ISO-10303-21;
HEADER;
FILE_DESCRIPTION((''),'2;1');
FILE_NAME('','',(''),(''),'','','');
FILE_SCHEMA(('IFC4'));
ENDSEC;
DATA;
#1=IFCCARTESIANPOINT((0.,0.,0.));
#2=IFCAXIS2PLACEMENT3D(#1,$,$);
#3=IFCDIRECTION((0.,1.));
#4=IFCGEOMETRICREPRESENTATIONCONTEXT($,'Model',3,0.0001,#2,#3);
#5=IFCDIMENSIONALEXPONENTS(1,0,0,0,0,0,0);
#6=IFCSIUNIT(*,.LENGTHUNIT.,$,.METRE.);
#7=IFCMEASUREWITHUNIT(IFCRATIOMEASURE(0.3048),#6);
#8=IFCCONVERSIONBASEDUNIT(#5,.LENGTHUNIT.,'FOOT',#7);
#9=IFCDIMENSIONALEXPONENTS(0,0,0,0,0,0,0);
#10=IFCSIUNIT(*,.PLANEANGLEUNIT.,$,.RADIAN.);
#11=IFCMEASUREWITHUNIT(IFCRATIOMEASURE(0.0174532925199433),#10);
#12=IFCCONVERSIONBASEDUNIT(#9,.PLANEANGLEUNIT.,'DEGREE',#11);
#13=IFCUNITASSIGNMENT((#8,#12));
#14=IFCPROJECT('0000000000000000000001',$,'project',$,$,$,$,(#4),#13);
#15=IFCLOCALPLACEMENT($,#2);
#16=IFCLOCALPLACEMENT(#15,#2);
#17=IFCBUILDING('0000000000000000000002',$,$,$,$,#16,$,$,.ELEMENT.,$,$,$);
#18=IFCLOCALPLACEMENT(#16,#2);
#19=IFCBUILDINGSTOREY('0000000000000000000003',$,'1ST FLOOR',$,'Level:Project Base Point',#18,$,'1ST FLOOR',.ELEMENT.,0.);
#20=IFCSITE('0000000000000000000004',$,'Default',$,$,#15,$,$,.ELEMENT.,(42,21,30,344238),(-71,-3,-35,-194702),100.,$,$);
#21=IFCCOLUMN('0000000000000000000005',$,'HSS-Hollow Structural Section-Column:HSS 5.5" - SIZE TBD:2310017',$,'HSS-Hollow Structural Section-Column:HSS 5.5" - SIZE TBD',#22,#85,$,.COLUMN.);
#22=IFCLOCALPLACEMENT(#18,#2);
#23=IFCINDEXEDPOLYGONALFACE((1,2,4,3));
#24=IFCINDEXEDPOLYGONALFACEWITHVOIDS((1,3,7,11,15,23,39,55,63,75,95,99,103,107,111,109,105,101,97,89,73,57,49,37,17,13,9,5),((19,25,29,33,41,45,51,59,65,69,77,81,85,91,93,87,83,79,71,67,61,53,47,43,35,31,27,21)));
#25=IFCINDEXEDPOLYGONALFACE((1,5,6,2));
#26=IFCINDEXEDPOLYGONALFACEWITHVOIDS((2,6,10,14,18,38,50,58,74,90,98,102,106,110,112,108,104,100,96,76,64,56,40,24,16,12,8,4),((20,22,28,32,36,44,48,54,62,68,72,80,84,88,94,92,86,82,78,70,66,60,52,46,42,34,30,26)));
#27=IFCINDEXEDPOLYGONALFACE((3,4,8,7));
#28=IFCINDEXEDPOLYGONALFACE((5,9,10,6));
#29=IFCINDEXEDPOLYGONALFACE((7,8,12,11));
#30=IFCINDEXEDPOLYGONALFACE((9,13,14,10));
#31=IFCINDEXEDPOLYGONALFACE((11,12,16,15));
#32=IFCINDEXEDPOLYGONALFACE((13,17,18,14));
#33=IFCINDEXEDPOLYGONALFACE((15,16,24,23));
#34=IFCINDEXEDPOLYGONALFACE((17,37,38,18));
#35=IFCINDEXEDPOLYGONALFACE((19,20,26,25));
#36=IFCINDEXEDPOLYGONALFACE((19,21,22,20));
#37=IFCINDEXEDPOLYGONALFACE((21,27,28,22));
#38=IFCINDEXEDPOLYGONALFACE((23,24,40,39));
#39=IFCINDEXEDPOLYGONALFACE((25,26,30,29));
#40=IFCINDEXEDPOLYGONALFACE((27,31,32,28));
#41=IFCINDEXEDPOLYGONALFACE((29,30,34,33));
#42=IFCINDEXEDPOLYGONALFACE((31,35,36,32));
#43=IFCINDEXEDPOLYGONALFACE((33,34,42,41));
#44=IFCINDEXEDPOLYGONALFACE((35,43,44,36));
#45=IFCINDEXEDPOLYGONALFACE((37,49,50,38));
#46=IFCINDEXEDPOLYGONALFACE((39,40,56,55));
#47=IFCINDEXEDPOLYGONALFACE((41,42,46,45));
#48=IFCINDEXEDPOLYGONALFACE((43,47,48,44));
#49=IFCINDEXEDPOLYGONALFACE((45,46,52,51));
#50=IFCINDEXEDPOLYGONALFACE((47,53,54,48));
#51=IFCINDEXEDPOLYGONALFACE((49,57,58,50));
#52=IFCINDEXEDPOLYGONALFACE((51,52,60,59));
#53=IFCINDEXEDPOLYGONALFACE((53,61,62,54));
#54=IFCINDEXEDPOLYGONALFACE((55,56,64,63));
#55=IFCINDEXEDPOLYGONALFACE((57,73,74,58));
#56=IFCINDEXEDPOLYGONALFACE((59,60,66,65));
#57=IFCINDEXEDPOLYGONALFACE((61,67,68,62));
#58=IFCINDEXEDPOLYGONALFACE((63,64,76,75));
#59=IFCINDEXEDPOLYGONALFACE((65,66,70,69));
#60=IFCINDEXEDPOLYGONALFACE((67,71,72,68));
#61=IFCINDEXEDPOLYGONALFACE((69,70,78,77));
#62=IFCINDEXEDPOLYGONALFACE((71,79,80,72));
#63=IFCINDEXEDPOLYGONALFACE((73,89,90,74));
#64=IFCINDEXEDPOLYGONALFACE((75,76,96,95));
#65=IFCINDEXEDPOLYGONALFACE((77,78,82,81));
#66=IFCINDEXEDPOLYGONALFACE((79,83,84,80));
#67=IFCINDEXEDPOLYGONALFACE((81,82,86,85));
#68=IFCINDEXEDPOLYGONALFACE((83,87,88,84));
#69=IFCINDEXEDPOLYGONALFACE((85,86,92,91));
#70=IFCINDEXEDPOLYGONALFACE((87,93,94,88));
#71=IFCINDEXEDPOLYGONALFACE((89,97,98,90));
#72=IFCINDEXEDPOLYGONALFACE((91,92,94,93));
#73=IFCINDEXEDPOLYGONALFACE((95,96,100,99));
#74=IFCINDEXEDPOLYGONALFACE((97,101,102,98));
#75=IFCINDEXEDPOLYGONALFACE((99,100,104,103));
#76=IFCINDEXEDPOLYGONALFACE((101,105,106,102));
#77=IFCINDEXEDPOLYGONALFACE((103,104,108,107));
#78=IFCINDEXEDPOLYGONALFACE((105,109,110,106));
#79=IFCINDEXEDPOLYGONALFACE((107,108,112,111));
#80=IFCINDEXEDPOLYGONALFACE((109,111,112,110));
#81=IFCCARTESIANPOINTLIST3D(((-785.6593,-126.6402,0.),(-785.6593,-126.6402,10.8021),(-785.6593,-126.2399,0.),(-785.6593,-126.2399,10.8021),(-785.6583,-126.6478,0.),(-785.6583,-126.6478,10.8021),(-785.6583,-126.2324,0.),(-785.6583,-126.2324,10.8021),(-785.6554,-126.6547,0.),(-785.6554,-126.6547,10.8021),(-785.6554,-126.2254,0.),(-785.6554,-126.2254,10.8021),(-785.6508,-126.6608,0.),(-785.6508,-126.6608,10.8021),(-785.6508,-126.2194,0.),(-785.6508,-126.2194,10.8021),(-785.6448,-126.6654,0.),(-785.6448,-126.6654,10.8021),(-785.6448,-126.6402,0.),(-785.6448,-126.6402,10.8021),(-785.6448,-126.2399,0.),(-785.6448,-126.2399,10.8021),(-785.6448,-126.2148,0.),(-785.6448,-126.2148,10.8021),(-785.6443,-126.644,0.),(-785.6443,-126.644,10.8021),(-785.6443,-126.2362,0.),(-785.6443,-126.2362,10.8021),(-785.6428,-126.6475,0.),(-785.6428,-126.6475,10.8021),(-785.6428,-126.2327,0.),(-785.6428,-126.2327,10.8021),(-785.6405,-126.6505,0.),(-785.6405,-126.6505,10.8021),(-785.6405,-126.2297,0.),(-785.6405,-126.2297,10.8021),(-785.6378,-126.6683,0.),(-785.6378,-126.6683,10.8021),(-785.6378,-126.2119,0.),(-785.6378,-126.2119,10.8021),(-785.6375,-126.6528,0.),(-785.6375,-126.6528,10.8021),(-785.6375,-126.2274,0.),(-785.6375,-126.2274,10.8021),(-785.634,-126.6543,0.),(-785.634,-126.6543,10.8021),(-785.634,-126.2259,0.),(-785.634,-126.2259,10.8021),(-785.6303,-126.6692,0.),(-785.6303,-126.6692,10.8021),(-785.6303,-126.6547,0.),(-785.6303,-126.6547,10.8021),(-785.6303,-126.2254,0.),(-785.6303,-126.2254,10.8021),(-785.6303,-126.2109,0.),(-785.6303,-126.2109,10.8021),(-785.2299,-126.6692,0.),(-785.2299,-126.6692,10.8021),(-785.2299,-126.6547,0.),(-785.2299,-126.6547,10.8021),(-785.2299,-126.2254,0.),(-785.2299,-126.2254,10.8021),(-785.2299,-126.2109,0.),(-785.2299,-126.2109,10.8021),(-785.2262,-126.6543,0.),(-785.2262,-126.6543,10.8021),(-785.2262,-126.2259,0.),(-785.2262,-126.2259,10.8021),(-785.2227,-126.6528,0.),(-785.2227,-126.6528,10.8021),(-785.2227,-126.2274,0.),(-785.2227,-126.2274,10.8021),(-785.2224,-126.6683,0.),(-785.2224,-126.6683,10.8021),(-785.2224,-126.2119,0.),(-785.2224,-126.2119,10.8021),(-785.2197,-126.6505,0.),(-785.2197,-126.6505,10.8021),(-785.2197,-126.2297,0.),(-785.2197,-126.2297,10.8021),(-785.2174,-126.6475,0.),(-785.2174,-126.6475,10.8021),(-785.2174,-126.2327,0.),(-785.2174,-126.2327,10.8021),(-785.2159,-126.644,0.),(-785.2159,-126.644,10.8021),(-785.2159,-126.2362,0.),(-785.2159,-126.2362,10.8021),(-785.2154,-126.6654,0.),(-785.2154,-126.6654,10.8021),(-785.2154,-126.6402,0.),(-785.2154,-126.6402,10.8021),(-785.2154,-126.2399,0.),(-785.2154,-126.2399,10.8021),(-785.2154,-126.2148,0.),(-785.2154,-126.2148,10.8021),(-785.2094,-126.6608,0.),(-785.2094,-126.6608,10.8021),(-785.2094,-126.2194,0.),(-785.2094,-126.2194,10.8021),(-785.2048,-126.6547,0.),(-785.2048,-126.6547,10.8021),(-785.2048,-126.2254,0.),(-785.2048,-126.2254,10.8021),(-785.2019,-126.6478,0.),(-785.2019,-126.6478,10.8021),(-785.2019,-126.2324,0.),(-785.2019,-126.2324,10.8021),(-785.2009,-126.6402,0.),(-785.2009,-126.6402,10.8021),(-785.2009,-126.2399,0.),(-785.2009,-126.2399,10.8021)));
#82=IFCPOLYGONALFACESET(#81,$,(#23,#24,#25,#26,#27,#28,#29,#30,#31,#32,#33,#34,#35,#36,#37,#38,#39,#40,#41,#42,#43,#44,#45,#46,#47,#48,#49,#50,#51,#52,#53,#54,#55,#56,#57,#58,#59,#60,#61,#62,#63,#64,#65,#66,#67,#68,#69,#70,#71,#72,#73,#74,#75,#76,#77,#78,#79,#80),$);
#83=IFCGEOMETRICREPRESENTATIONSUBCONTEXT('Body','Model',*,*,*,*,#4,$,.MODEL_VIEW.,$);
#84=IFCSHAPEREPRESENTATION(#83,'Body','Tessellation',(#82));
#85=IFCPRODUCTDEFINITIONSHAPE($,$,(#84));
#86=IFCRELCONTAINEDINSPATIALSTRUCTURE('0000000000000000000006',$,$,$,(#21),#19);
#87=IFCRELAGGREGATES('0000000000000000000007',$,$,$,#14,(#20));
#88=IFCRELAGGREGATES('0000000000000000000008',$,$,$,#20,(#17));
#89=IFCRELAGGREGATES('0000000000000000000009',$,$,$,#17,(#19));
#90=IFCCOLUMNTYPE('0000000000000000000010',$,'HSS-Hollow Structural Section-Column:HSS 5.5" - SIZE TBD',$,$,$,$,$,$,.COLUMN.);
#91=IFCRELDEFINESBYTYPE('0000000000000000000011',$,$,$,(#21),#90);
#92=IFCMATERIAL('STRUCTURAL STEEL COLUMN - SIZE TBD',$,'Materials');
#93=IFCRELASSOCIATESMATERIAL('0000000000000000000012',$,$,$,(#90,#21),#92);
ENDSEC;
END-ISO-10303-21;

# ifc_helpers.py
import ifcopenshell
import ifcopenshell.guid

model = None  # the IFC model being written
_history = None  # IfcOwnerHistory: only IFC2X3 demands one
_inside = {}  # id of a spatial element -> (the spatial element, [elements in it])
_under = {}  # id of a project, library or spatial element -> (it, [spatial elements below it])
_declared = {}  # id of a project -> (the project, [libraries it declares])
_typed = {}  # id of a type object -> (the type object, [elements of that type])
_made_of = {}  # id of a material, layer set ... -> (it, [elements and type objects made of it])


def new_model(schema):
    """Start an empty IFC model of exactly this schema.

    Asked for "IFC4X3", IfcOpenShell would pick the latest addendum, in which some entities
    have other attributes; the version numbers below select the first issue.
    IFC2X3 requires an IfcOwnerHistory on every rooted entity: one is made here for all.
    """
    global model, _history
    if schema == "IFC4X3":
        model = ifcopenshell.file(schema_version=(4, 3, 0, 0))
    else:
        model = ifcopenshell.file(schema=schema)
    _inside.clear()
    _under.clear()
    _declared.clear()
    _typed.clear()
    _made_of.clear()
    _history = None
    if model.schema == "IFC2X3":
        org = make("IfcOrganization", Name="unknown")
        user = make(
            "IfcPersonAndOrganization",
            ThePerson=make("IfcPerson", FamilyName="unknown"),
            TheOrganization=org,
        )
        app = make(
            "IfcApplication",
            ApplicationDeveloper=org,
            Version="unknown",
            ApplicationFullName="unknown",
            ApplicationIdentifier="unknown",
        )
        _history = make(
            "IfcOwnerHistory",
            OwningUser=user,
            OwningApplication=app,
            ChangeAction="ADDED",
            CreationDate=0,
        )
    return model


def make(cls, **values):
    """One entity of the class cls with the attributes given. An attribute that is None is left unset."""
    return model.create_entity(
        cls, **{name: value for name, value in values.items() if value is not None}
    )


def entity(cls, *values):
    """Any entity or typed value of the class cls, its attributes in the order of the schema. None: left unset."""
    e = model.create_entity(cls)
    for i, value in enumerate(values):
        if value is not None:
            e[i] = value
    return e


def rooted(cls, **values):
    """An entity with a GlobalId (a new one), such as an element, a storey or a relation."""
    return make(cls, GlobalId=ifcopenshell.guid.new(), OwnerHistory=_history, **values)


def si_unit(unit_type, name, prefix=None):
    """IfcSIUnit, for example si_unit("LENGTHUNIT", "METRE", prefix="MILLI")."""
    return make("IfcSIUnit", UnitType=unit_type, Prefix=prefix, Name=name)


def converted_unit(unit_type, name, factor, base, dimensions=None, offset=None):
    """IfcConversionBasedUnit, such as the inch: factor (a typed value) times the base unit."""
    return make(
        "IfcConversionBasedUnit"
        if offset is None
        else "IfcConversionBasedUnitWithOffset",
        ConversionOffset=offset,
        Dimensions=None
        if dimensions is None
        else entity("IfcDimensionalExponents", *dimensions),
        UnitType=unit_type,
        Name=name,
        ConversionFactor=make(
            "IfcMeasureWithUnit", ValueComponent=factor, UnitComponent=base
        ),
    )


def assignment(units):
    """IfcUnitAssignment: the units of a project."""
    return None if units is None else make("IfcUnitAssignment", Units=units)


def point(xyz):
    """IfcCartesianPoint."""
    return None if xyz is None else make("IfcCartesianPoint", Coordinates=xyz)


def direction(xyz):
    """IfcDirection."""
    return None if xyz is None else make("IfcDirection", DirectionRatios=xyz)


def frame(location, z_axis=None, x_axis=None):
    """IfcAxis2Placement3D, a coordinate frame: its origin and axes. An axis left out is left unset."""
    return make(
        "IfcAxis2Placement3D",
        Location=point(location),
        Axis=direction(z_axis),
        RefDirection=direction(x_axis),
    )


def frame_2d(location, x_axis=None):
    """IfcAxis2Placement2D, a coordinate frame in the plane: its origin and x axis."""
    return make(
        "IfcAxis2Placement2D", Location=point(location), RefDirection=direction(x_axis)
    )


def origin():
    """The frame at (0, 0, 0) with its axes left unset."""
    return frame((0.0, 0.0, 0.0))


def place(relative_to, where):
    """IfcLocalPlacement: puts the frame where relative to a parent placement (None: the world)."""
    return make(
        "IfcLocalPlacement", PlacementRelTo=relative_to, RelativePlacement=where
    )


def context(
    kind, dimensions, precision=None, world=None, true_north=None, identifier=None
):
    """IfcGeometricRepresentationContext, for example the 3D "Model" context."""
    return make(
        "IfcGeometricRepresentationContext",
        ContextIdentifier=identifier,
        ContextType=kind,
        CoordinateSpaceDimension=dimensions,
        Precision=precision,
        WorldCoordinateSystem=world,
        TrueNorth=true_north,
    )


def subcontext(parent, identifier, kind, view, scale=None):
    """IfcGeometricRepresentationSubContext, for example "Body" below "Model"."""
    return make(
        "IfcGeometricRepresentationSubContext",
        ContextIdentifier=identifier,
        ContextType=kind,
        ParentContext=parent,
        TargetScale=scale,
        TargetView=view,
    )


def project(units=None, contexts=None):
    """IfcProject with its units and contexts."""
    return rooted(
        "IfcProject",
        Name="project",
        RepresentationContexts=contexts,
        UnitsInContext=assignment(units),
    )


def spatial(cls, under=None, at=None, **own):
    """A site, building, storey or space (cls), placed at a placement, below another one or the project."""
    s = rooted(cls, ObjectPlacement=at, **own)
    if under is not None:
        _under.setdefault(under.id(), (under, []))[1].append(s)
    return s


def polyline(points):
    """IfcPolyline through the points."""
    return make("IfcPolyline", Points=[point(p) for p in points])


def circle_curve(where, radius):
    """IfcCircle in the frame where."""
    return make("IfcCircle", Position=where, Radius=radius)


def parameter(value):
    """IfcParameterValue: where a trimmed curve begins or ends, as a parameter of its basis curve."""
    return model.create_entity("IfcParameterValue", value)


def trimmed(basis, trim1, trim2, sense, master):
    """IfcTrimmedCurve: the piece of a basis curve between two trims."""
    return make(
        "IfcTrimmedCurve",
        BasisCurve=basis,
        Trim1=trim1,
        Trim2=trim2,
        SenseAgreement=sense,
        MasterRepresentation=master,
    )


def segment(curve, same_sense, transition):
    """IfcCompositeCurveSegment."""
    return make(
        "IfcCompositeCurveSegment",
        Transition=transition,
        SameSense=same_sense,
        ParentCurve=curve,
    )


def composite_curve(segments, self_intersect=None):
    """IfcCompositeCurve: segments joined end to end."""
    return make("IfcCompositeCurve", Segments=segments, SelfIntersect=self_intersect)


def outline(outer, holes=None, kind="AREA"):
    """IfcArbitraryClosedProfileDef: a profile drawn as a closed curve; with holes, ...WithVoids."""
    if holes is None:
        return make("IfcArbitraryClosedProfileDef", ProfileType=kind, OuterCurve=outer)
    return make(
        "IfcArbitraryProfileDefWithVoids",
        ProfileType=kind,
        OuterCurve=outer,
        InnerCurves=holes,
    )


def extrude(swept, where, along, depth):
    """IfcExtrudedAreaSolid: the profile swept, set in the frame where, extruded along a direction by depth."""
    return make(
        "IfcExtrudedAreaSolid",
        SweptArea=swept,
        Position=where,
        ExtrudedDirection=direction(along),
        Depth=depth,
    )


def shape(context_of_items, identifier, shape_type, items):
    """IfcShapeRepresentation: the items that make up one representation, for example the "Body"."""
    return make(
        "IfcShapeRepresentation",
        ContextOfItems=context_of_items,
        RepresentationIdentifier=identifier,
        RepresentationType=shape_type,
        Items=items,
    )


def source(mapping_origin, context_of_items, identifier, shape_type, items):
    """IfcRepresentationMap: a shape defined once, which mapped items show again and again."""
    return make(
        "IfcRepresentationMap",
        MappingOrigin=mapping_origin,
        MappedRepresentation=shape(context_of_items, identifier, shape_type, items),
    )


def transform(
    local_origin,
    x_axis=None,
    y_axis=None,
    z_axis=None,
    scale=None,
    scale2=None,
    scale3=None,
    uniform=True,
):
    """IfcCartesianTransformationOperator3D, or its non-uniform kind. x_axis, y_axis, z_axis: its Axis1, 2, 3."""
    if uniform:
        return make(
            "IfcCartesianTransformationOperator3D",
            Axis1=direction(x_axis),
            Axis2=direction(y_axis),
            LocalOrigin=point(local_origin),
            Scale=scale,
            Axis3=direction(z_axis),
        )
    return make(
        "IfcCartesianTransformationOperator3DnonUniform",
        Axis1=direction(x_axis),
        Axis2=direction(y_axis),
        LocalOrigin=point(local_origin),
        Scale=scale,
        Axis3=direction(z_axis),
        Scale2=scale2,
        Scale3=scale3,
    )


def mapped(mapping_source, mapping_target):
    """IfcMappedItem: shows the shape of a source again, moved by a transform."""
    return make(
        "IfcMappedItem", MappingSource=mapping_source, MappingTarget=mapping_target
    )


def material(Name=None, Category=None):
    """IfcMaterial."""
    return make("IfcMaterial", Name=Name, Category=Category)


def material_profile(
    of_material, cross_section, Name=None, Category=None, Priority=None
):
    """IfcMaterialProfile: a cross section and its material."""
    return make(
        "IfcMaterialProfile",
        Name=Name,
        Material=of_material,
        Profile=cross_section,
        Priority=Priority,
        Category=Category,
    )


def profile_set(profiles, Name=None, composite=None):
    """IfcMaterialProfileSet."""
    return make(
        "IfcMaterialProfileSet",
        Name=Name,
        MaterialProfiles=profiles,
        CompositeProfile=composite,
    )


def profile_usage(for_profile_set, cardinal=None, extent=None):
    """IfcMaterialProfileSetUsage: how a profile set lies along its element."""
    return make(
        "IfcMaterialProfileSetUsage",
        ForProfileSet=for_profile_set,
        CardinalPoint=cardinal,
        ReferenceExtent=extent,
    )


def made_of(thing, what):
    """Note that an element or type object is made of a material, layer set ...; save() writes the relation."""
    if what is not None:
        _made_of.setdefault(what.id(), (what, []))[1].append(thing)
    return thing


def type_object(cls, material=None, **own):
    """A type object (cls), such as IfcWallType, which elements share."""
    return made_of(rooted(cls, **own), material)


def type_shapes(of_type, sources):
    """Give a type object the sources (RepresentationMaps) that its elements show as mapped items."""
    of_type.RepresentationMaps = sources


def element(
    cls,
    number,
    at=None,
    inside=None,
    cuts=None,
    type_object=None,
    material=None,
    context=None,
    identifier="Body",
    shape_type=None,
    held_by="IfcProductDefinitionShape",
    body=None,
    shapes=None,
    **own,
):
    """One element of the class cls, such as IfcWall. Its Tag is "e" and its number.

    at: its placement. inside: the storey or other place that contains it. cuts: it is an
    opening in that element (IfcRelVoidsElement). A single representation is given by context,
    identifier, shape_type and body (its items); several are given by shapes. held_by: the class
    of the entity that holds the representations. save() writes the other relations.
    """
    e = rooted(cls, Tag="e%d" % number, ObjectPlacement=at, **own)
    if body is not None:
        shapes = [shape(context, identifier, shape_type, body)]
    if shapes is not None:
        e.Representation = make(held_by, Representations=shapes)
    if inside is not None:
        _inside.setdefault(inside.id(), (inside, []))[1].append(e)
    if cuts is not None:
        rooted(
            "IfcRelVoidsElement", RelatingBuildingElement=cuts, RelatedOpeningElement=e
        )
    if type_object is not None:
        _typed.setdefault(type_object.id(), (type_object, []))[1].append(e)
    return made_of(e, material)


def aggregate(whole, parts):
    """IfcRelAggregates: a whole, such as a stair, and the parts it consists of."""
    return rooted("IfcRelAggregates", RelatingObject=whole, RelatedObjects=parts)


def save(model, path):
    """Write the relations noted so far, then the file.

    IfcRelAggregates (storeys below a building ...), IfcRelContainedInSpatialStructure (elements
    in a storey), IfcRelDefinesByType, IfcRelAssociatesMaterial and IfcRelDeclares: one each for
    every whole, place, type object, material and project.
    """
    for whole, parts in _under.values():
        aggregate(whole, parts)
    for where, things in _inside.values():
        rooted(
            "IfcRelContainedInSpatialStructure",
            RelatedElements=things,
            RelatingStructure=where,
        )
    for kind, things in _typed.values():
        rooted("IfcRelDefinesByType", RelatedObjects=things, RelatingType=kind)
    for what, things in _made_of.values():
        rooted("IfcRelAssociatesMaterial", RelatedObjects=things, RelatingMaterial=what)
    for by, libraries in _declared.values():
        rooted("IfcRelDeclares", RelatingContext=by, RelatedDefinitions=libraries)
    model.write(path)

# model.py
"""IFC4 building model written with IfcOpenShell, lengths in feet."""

from ifc_helpers import new_model, entity, si_unit, converted_unit, direction, frame, frame_2d, origin, place, context, subcontext, project, spatial, polyline, circle_curve, parameter, trimmed, segment, composite_curve, outline, extrude, source, transform, mapped, material, material_profile, profile_set, profile_usage, type_object, type_shapes, element, save


model = new_model("IFC4")

# Units and contexts
model_context = context("Model", 3, precision=0.0001, world=origin(), true_north=direction((0.0, 1.0)))
body_context = subcontext(model_context, "Body", "Model", "MODEL_VIEW")
ifc_project = project(units=[converted_unit("LENGTHUNIT", "FOOT", entity("IfcRatioMeasure", 0.3048), si_unit("LENGTHUNIT", "METRE"), dimensions=[1, 0, 0, 0, 0, 0, 0]), converted_unit("PLANEANGLEUNIT", "DEGREE", entity("IfcRatioMeasure", 0.0174532925199433), si_unit("PLANEANGLEUNIT", "RADIAN"), dimensions=[0, 0, 0, 0, 0, 0, 0])], contexts=[model_context])

# Site, building, storey
site_placement = place(None, origin())
site = spatial("IfcSite", under=ifc_project, at=site_placement, Name="Default", CompositionType="ELEMENT", RefLatitude=(42, 21, 30, 344238), RefLongitude=(-71, -3, -35, -194702), RefElevation=100.0)
building_placement = place(site_placement, origin())
building = spatial("IfcBuilding", under=site, at=building_placement, CompositionType="ELEMENT")
storey_placement = place(building_placement, origin())
storey = spatial("IfcBuildingStorey", under=building, at=storey_placement, Name="1ST FLOOR", ObjectType="Level:Project Base Point", LongName="1ST FLOOR", CompositionType="ELEMENT", Elevation=0.0)

# Column
ifc_material_1 = material(Name="STRUCTURAL STEEL COLUMN - SIZE TBD", Category="Materials")
ifc_material_profile_1 = material_profile(ifc_material_1, outline(composite_curve([segment(polyline([(-0.2002, -0.2292), (0.2002, -0.2292)]), True, "CONTINUOUS"), segment(trimmed(circle_curve(frame_2d((0.2002, -0.2002), x_axis=(-1.0, 0.0)), 0.029), [parameter(90.0)], [parameter(180.0)], True, "PARAMETER"), True, "CONTINUOUS"), segment(polyline([(0.2292, -0.2002), (0.2292, 0.2002)]), True, "CONTINUOUS"), segment(trimmed(circle_curve(frame_2d((0.2002, 0.2002), x_axis=(-1.0, 0.0)), 0.029), [parameter(180.0)], [parameter(270.0)], True, "PARAMETER"), True, "CONTINUOUS"), segment(polyline([(0.2002, 0.2292), (-0.2002, 0.2292)]), True, "CONTINUOUS"), segment(trimmed(circle_curve(frame_2d((-0.2002, 0.2002), x_axis=(-1.0, 0.0)), 0.029), [parameter(270.0)], [parameter(360.0)], True, "PARAMETER"), True, "CONTINUOUS"), segment(polyline([(-0.2292, 0.2002), (-0.2292, -0.2002)]), True, "CONTINUOUS"), segment(trimmed(circle_curve(frame_2d((-0.2002, -0.2002), x_axis=(-1.0, 0.0)), 0.029), [parameter(360.0)], [parameter(90.0)], True, "PARAMETER"), True, "CONTINUOUS")], self_intersect=False), holes=[composite_curve([segment(trimmed(circle_curve(frame_2d((-0.2002, -0.2002), x_axis=(-1.0, 0.0)), 0.0145), [parameter(0.0)], [parameter(90.0)], True, "PARAMETER"), False, "CONTINUOUS"), segment(polyline([(-0.2147, -0.2002), (-0.2147, 0.2002)]), True, "CONTINUOUS"), segment(trimmed(circle_curve(frame_2d((-0.2002, 0.2002), x_axis=(-1.0, 0.0)), 0.0145), [parameter(270.0)], [parameter(0.0)], True, "PARAMETER"), False, "CONTINUOUS"), segment(polyline([(-0.2002, 0.2147), (0.2002, 0.2147)]), True, "CONTINUOUS"), segment(trimmed(circle_curve(frame_2d((0.2002, 0.2002), x_axis=(-1.0, 0.0)), 0.0145), [parameter(180.0)], [parameter(270.0)], True, "PARAMETER"), False, "CONTINUOUS"), segment(polyline([(0.2147, 0.2002), (0.2147, -0.2002)]), True, "CONTINUOUS"), segment(trimmed(circle_curve(frame_2d((0.2002, -0.2002), x_axis=(-1.0, 0.0)), 0.0145), [parameter(90.0)], [parameter(180.0)], True, "PARAMETER"), False, "CONTINUOUS"), segment(polyline([(0.2002, -0.2147), (-0.2002, -0.2147)]), True, "CONTINUOUS")], self_intersect=False)]), Name="HSS 5.5\" - SIZE TBD")
ifc_profile_set_1 = profile_set([ifc_material_profile_1], Name="HSS 5.5\" - SIZE TBD")
ifc_profile_usage_1 = profile_usage(ifc_profile_set_1)
column_type_1 = type_object("IfcColumnType", Name="HSS-Hollow Structural Section-Column:HSS 5.5\" - SIZE TBD", PredefinedType="COLUMN", material=ifc_profile_set_1)
shared_shape_1 = source(origin(), body_context, "Body", "SweptSolid", [
    extrude(outline(composite_curve([segment(polyline([(-0.2002, -0.2292), (0.2002, -0.2292)]), True, "CONTINUOUS"), segment(trimmed(circle_curve(frame_2d((0.2002, -0.2002), x_axis=(-1.0, 0.0)), 0.029), [parameter(90.0)], [parameter(180.0)], True, "PARAMETER"), True, "CONTINUOUS"), segment(polyline([(0.2292, -0.2002), (0.2292, 0.2002)]), True, "CONTINUOUS"), segment(trimmed(circle_curve(frame_2d((0.2002, 0.2002), x_axis=(-1.0, 0.0)), 0.029), [parameter(180.0)], [parameter(270.0)], True, "PARAMETER"), True, "CONTINUOUS"), segment(polyline([(0.2002, 0.2292), (-0.2002, 0.2292)]), True, "CONTINUOUS"), segment(trimmed(circle_curve(frame_2d((-0.2002, 0.2002), x_axis=(-1.0, 0.0)), 0.029), [parameter(270.0)], [parameter(360.0)], True, "PARAMETER"), True, "CONTINUOUS"), segment(polyline([(-0.2292, 0.2002), (-0.2292, -0.2002)]), True, "CONTINUOUS"), segment(trimmed(circle_curve(frame_2d((-0.2002, -0.2002), x_axis=(-1.0, 0.0)), 0.029), [parameter(360.0)], [parameter(90.0)], True, "PARAMETER"), True, "CONTINUOUS")], self_intersect=False), holes=[composite_curve([segment(trimmed(circle_curve(frame_2d((-0.2002, -0.2002), x_axis=(-1.0, 0.0)), 0.0145), [parameter(0.0)], [parameter(90.0)], True, "PARAMETER"), False, "CONTINUOUS"), segment(polyline([(-0.2147, -0.2002), (-0.2147, 0.2002)]), True, "CONTINUOUS"), segment(trimmed(circle_curve(frame_2d((-0.2002, 0.2002), x_axis=(-1.0, 0.0)), 0.0145), [parameter(270.0)], [parameter(0.0)], True, "PARAMETER"), False, "CONTINUOUS"), segment(polyline([(-0.2002, 0.2147), (0.2002, 0.2147)]), True, "CONTINUOUS"), segment(trimmed(circle_curve(frame_2d((0.2002, 0.2002), x_axis=(-1.0, 0.0)), 0.0145), [parameter(180.0)], [parameter(270.0)], True, "PARAMETER"), False, "CONTINUOUS"), segment(polyline([(0.2147, 0.2002), (0.2147, -0.2002)]), True, "CONTINUOUS"), segment(trimmed(circle_curve(frame_2d((0.2002, -0.2002), x_axis=(-1.0, 0.0)), 0.0145), [parameter(90.0)], [parameter(180.0)], True, "PARAMETER"), False, "CONTINUOUS"), segment(polyline([(0.2002, -0.2147), (-0.2002, -0.2147)]), True, "CONTINUOUS")], self_intersect=False)]), frame((0.0, 0.0, 0.0), z_axis=(0.0, 0.0, 1.0), x_axis=(-1.0, 0.0, 0.0)), (0.0, 0.0, 1.0), 10.8021),
])
type_shapes(column_type_1, [shared_shape_1])
column_1_placement = place(storey_placement, frame((-785.4301, -126.4401, 0.0)))
element("IfcColumn", 1, at=column_1_placement, inside=storey, type_object=column_type_1, material=ifc_profile_usage_1, Name="HSS-Hollow Structural Section-Column:HSS 5.5\" - SIZE TBD:2310017", ObjectType="HSS-Hollow Structural Section-Column:HSS 5.5\" - SIZE TBD", PredefinedType="COLUMN", context=body_context, shape_type="MappedRepresentation", body=[
    mapped(shared_shape_1, transform((0.0, 0.0, 0.0), scale=1.0)),
])

save(model, "model.ifc")
